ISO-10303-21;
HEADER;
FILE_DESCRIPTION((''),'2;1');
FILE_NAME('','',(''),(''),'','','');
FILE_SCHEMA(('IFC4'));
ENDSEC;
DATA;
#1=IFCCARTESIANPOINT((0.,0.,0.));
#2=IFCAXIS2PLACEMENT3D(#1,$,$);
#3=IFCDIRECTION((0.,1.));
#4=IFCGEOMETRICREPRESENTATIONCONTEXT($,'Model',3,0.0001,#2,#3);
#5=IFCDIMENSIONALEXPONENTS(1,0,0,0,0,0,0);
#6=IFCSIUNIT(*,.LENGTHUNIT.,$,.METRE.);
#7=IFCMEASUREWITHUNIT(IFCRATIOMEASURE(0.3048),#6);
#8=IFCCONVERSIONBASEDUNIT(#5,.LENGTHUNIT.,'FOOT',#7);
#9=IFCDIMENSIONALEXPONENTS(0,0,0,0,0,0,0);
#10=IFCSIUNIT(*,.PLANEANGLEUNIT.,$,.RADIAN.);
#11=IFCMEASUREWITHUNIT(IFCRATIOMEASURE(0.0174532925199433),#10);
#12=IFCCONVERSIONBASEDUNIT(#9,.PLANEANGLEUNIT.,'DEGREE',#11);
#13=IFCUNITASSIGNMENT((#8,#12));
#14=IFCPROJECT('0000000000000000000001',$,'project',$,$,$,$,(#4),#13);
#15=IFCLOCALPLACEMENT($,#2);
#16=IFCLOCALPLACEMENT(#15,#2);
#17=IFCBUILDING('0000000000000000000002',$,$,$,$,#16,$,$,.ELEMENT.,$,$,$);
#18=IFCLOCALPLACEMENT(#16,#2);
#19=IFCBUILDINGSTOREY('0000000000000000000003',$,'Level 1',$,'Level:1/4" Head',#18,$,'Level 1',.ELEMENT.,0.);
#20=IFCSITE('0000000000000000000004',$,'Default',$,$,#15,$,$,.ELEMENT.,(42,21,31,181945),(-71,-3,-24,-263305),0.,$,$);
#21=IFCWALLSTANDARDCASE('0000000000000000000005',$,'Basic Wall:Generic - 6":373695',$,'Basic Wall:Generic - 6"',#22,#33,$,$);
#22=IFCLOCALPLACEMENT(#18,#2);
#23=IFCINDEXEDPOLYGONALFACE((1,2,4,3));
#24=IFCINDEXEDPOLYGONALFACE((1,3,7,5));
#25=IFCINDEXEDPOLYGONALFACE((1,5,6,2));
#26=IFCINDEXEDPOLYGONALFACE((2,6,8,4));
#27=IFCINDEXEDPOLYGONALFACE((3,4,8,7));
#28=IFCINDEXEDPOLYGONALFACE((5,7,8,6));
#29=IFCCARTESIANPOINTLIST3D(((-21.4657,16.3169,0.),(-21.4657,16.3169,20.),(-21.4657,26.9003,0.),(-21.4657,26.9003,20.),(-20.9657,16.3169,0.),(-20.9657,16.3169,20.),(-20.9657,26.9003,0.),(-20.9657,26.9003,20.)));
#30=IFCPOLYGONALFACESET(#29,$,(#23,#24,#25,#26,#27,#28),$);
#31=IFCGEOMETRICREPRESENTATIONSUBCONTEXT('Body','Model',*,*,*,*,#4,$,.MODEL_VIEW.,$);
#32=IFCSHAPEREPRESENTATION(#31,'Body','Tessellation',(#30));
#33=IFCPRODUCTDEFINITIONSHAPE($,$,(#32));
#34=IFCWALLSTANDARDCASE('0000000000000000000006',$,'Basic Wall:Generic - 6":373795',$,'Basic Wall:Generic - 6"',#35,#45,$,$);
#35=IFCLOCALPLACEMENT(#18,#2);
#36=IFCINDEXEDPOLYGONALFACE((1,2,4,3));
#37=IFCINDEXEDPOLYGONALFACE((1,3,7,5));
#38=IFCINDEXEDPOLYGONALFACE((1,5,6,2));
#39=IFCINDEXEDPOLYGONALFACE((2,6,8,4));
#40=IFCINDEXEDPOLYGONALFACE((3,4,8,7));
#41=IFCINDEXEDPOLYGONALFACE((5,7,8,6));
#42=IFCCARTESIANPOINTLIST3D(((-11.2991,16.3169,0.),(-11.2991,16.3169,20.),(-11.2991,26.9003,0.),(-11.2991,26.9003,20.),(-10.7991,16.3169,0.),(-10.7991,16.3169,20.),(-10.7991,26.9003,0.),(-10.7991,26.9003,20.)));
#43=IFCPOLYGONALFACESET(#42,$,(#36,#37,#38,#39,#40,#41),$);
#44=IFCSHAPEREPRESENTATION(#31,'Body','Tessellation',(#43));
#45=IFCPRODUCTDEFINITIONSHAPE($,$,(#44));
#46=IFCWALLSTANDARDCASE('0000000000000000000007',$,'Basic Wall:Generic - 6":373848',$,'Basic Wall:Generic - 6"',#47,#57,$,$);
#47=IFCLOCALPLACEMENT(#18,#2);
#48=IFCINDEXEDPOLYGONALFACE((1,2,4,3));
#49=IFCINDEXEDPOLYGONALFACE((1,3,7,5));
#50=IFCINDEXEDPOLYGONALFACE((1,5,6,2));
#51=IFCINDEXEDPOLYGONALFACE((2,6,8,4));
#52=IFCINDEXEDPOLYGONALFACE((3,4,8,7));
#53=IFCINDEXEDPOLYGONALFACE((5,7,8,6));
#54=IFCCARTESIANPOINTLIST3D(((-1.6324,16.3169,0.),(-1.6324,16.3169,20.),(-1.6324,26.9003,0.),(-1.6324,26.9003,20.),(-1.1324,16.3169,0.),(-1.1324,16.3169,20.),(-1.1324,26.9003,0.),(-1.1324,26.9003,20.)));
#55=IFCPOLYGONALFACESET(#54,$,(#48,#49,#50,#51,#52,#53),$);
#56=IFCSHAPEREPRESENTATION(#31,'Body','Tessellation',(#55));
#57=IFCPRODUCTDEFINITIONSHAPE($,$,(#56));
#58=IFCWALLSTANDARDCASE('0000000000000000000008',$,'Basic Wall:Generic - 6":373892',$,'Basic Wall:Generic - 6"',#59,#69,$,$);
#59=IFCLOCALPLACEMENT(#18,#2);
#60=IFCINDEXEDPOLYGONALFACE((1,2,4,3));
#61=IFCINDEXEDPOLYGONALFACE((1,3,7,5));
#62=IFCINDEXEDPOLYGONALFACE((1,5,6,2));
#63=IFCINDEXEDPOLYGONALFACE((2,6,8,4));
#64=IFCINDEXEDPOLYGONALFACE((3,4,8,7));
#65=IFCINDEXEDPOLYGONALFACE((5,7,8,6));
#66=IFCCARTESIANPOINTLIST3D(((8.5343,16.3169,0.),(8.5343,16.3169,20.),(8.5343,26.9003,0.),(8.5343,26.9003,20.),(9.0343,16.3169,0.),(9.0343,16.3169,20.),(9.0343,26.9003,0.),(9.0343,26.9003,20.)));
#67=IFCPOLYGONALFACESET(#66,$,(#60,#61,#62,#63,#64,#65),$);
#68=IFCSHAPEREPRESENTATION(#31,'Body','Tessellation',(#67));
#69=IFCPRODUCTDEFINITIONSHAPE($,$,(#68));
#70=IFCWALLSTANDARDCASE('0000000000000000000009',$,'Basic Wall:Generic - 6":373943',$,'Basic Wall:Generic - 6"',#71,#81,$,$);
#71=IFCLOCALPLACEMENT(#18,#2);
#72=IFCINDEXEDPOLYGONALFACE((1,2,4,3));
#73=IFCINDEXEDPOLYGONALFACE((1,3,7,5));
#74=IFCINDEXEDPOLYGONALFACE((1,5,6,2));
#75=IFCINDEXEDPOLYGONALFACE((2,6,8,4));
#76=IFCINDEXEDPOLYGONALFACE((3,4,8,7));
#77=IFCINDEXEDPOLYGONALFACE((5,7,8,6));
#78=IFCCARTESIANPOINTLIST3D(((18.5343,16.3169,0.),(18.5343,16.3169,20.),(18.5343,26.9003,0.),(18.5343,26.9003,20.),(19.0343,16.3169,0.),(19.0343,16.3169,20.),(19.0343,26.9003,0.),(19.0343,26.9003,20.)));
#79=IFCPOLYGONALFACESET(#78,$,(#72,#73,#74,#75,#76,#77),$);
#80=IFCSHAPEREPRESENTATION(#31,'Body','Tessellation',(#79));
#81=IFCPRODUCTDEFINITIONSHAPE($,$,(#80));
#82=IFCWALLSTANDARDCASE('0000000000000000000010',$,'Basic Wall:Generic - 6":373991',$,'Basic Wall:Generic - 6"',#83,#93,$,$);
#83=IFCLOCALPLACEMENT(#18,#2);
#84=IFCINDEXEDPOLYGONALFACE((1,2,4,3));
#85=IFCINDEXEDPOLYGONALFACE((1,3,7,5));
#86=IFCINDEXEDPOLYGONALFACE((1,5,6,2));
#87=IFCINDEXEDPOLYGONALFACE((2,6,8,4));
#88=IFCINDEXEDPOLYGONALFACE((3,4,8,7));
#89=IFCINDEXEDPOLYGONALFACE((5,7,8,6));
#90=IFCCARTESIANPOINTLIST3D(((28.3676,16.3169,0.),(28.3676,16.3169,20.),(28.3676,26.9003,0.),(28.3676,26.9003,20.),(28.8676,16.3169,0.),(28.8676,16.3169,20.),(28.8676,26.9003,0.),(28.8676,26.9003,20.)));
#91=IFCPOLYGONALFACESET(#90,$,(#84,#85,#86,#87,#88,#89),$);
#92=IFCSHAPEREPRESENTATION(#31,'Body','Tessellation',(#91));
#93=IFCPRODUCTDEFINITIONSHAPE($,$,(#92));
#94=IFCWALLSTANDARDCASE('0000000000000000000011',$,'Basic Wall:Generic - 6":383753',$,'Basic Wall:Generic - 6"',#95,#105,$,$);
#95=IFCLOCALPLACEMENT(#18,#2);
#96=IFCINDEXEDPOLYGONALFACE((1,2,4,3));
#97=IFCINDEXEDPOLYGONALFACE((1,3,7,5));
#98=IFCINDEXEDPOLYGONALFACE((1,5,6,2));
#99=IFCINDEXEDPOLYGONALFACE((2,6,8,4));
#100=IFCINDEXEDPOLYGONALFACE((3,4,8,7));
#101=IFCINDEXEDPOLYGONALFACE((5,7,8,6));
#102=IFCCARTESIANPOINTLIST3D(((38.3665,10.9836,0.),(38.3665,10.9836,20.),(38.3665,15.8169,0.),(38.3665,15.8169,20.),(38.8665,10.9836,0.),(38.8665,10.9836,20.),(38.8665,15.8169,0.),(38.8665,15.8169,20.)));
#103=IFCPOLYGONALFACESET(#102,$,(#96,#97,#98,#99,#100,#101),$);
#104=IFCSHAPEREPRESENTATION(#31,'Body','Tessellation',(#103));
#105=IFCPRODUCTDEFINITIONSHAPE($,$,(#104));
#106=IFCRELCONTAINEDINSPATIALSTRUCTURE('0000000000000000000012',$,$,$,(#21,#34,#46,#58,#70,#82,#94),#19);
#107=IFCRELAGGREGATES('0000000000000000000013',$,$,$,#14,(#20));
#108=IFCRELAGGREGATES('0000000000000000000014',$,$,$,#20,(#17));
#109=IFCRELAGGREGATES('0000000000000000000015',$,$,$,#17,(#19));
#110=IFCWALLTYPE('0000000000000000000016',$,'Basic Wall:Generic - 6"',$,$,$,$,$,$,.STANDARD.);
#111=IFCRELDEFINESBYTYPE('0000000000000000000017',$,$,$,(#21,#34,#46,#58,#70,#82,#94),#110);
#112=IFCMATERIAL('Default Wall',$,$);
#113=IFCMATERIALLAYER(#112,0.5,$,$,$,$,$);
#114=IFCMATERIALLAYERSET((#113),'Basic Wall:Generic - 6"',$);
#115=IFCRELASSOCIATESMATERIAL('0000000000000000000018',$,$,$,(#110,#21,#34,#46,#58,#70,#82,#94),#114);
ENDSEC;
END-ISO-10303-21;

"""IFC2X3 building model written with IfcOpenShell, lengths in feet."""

from ifc_helpers import new_model, entity, si_unit, converted_unit, direction, frame, frame_2d, origin, place, context, subcontext, project, spatial, rectangle, extrude, material, layer, layer_set, layer_usage, type_object, element, save


model = new_model("IFC2X3")

# Units and contexts
model_context = context("Model", 3, precision=0.0001, world=origin(), true_north=direction((0.0, 1.0)))
body_context = subcontext(model_context, "Body", "Model", "MODEL_VIEW")
ifc_project = project(units=[converted_unit("LENGTHUNIT", "FOOT", entity("IfcRatioMeasure", 0.3048), si_unit("LENGTHUNIT", "METRE"), dimensions=[1, 0, 0, 0, 0, 0, 0]), converted_unit("PLANEANGLEUNIT", "DEGREE", entity("IfcRatioMeasure", 0.0174532925199433), si_unit("PLANEANGLEUNIT", "RADIAN"), dimensions=[0, 0, 0, 0, 0, 0, 0])], contexts=[model_context])

# Site, building, storey
site_placement = place(None, origin())
site = spatial("IfcSite", under=ifc_project, at=site_placement, Name="Default", CompositionType="ELEMENT", RefLatitude=(42, 21, 31, 181945), RefLongitude=(-71, -3, -24, -263305), RefElevation=0.0)
building_placement = place(site_placement, origin())
building = spatial("IfcBuilding", under=site, at=building_placement, CompositionType="ELEMENT")
storey_placement = place(building_placement, origin())
storey = spatial("IfcBuildingStorey", under=building, at=storey_placement, Name="Level 1", ObjectType="Level:1/4\" Head", LongName="Level 1", CompositionType="ELEMENT", Elevation=0.0)

# Walls
ifc_material = material(Name="Default Wall")
ifc_layer_1 = layer(ifc_material, 0.5)
ifc_layer_set_1 = layer_set([ifc_layer_1], Name="Basic Wall:Generic - 6\"")
wall_type_1 = type_object("IfcWallType", Name="Basic Wall:Generic - 6\"", PredefinedType="STANDARD", material=ifc_layer_set_1)
ifc_layer_usage_1 = layer_usage(ifc_layer_set_1, "AXIS2", "NEGATIVE", 0.25)
wall_1_placement = place(storey_placement, frame((-21.2157, 26.9003, 0.0), z_axis=(0.0, 0.0, 1.0), x_axis=(0.0, -1.0, 0.0)))
element("IfcWallStandardCase", 1, at=wall_1_placement, inside=storey, type_object=wall_type_1, material=ifc_layer_usage_1, Name="Basic Wall:Generic - 6\":373695", ObjectType="Basic Wall:Generic - 6\"", context=body_context, shape_type="SweptSolid", body=[
    extrude(rectangle(XDim=10.5833, YDim=0.5, at=frame_2d((5.2917, 0.0), x_axis=(-1.0, 0.0))), origin(), (0.0, 0.0, 1.0), 20.0),
])
ifc_layer_usage_2 = layer_usage(ifc_layer_set_1, "AXIS2", "NEGATIVE", 0.25)
wall_2_placement = place(storey_placement, frame((-11.0491, 26.9003, 0.0), z_axis=(0.0, 0.0, 1.0), x_axis=(0.0, -1.0, 0.0)))
element("IfcWallStandardCase", 2, at=wall_2_placement, inside=storey, type_object=wall_type_1, material=ifc_layer_usage_2, Name="Basic Wall:Generic - 6\":373795", ObjectType="Basic Wall:Generic - 6\"", context=body_context, shape_type="SweptSolid", body=[
    extrude(rectangle(XDim=10.5833, YDim=0.5, at=frame_2d((5.2917, 0.0), x_axis=(-1.0, 0.0))), origin(), (0.0, 0.0, 1.0), 20.0),
])
ifc_layer_usage_3 = layer_usage(ifc_layer_set_1, "AXIS2", "NEGATIVE", 0.25)
wall_3_placement = place(storey_placement, frame((-1.3824, 26.9003, 0.0), z_axis=(0.0, 0.0, 1.0), x_axis=(0.0, -1.0, 0.0)))
element("IfcWallStandardCase", 3, at=wall_3_placement, inside=storey, type_object=wall_type_1, material=ifc_layer_usage_3, Name="Basic Wall:Generic - 6\":373848", ObjectType="Basic Wall:Generic - 6\"", context=body_context, shape_type="SweptSolid", body=[
    extrude(rectangle(XDim=10.5833, YDim=0.5, at=frame_2d((5.2917, 0.0), x_axis=(-1.0, 0.0))), origin(), (0.0, 0.0, 1.0), 20.0),
])
ifc_layer_usage_4 = layer_usage(ifc_layer_set_1, "AXIS2", "NEGATIVE", 0.25)
wall_4_placement = place(storey_placement, frame((8.7843, 26.9003, 0.0), z_axis=(0.0, 0.0, 1.0), x_axis=(0.0, -1.0, 0.0)))
element("IfcWallStandardCase", 4, at=wall_4_placement, inside=storey, type_object=wall_type_1, material=ifc_layer_usage_4, Name="Basic Wall:Generic - 6\":373892", ObjectType="Basic Wall:Generic - 6\"", context=body_context, shape_type="SweptSolid", body=[
    extrude(rectangle(XDim=10.5833, YDim=0.5, at=frame_2d((5.2917, 0.0), x_axis=(-1.0, 0.0))), origin(), (0.0, 0.0, 1.0), 20.0),
])
ifc_layer_usage_5 = layer_usage(ifc_layer_set_1, "AXIS2", "NEGATIVE", 0.25)
wall_5_placement = place(storey_placement, frame((18.7843, 26.9003, 0.0), z_axis=(0.0, 0.0, 1.0), x_axis=(0.0, -1.0, 0.0)))
element("IfcWallStandardCase", 5, at=wall_5_placement, inside=storey, type_object=wall_type_1, material=ifc_layer_usage_5, Name="Basic Wall:Generic - 6\":373943", ObjectType="Basic Wall:Generic - 6\"", context=body_context, shape_type="SweptSolid", body=[
    extrude(rectangle(XDim=10.5833, YDim=0.5, at=frame_2d((5.2917, 0.0), x_axis=(-1.0, 0.0))), origin(), (0.0, 0.0, 1.0), 20.0),
])
ifc_layer_usage_6 = layer_usage(ifc_layer_set_1, "AXIS2", "NEGATIVE", 0.25)
wall_6_placement = place(storey_placement, frame((28.6176, 26.9003, 0.0), z_axis=(0.0, 0.0, 1.0), x_axis=(0.0, -1.0, 0.0)))
element("IfcWallStandardCase", 6, at=wall_6_placement, inside=storey, type_object=wall_type_1, material=ifc_layer_usage_6, Name="Basic Wall:Generic - 6\":373991", ObjectType="Basic Wall:Generic - 6\"", context=body_context, shape_type="SweptSolid", body=[
    extrude(rectangle(XDim=10.5833, YDim=0.5, at=frame_2d((5.2917, 0.0), x_axis=(-1.0, 0.0))), origin(), (0.0, 0.0, 1.0), 20.0),
])
ifc_layer_usage_7 = layer_usage(ifc_layer_set_1, "AXIS2", "NEGATIVE", 0.25)
wall_7_placement = place(storey_placement, frame((38.6165, 10.9836, 0.0), z_axis=(0.0, 0.0, 1.0), x_axis=(0.0, 1.0, 0.0)))
element("IfcWallStandardCase", 7, at=wall_7_placement, inside=storey, type_object=wall_type_1, material=ifc_layer_usage_7, Name="Basic Wall:Generic - 6\":383753", ObjectType="Basic Wall:Generic - 6\"", context=body_context, shape_type="SweptSolid", body=[
    extrude(rectangle(XDim=4.8333, YDim=0.5, at=frame_2d((2.4167, 0.0), x_axis=(-1.0, 0.0))), origin(), (0.0, 0.0, 1.0), 20.0),
])

save(model, "model.ifc")
